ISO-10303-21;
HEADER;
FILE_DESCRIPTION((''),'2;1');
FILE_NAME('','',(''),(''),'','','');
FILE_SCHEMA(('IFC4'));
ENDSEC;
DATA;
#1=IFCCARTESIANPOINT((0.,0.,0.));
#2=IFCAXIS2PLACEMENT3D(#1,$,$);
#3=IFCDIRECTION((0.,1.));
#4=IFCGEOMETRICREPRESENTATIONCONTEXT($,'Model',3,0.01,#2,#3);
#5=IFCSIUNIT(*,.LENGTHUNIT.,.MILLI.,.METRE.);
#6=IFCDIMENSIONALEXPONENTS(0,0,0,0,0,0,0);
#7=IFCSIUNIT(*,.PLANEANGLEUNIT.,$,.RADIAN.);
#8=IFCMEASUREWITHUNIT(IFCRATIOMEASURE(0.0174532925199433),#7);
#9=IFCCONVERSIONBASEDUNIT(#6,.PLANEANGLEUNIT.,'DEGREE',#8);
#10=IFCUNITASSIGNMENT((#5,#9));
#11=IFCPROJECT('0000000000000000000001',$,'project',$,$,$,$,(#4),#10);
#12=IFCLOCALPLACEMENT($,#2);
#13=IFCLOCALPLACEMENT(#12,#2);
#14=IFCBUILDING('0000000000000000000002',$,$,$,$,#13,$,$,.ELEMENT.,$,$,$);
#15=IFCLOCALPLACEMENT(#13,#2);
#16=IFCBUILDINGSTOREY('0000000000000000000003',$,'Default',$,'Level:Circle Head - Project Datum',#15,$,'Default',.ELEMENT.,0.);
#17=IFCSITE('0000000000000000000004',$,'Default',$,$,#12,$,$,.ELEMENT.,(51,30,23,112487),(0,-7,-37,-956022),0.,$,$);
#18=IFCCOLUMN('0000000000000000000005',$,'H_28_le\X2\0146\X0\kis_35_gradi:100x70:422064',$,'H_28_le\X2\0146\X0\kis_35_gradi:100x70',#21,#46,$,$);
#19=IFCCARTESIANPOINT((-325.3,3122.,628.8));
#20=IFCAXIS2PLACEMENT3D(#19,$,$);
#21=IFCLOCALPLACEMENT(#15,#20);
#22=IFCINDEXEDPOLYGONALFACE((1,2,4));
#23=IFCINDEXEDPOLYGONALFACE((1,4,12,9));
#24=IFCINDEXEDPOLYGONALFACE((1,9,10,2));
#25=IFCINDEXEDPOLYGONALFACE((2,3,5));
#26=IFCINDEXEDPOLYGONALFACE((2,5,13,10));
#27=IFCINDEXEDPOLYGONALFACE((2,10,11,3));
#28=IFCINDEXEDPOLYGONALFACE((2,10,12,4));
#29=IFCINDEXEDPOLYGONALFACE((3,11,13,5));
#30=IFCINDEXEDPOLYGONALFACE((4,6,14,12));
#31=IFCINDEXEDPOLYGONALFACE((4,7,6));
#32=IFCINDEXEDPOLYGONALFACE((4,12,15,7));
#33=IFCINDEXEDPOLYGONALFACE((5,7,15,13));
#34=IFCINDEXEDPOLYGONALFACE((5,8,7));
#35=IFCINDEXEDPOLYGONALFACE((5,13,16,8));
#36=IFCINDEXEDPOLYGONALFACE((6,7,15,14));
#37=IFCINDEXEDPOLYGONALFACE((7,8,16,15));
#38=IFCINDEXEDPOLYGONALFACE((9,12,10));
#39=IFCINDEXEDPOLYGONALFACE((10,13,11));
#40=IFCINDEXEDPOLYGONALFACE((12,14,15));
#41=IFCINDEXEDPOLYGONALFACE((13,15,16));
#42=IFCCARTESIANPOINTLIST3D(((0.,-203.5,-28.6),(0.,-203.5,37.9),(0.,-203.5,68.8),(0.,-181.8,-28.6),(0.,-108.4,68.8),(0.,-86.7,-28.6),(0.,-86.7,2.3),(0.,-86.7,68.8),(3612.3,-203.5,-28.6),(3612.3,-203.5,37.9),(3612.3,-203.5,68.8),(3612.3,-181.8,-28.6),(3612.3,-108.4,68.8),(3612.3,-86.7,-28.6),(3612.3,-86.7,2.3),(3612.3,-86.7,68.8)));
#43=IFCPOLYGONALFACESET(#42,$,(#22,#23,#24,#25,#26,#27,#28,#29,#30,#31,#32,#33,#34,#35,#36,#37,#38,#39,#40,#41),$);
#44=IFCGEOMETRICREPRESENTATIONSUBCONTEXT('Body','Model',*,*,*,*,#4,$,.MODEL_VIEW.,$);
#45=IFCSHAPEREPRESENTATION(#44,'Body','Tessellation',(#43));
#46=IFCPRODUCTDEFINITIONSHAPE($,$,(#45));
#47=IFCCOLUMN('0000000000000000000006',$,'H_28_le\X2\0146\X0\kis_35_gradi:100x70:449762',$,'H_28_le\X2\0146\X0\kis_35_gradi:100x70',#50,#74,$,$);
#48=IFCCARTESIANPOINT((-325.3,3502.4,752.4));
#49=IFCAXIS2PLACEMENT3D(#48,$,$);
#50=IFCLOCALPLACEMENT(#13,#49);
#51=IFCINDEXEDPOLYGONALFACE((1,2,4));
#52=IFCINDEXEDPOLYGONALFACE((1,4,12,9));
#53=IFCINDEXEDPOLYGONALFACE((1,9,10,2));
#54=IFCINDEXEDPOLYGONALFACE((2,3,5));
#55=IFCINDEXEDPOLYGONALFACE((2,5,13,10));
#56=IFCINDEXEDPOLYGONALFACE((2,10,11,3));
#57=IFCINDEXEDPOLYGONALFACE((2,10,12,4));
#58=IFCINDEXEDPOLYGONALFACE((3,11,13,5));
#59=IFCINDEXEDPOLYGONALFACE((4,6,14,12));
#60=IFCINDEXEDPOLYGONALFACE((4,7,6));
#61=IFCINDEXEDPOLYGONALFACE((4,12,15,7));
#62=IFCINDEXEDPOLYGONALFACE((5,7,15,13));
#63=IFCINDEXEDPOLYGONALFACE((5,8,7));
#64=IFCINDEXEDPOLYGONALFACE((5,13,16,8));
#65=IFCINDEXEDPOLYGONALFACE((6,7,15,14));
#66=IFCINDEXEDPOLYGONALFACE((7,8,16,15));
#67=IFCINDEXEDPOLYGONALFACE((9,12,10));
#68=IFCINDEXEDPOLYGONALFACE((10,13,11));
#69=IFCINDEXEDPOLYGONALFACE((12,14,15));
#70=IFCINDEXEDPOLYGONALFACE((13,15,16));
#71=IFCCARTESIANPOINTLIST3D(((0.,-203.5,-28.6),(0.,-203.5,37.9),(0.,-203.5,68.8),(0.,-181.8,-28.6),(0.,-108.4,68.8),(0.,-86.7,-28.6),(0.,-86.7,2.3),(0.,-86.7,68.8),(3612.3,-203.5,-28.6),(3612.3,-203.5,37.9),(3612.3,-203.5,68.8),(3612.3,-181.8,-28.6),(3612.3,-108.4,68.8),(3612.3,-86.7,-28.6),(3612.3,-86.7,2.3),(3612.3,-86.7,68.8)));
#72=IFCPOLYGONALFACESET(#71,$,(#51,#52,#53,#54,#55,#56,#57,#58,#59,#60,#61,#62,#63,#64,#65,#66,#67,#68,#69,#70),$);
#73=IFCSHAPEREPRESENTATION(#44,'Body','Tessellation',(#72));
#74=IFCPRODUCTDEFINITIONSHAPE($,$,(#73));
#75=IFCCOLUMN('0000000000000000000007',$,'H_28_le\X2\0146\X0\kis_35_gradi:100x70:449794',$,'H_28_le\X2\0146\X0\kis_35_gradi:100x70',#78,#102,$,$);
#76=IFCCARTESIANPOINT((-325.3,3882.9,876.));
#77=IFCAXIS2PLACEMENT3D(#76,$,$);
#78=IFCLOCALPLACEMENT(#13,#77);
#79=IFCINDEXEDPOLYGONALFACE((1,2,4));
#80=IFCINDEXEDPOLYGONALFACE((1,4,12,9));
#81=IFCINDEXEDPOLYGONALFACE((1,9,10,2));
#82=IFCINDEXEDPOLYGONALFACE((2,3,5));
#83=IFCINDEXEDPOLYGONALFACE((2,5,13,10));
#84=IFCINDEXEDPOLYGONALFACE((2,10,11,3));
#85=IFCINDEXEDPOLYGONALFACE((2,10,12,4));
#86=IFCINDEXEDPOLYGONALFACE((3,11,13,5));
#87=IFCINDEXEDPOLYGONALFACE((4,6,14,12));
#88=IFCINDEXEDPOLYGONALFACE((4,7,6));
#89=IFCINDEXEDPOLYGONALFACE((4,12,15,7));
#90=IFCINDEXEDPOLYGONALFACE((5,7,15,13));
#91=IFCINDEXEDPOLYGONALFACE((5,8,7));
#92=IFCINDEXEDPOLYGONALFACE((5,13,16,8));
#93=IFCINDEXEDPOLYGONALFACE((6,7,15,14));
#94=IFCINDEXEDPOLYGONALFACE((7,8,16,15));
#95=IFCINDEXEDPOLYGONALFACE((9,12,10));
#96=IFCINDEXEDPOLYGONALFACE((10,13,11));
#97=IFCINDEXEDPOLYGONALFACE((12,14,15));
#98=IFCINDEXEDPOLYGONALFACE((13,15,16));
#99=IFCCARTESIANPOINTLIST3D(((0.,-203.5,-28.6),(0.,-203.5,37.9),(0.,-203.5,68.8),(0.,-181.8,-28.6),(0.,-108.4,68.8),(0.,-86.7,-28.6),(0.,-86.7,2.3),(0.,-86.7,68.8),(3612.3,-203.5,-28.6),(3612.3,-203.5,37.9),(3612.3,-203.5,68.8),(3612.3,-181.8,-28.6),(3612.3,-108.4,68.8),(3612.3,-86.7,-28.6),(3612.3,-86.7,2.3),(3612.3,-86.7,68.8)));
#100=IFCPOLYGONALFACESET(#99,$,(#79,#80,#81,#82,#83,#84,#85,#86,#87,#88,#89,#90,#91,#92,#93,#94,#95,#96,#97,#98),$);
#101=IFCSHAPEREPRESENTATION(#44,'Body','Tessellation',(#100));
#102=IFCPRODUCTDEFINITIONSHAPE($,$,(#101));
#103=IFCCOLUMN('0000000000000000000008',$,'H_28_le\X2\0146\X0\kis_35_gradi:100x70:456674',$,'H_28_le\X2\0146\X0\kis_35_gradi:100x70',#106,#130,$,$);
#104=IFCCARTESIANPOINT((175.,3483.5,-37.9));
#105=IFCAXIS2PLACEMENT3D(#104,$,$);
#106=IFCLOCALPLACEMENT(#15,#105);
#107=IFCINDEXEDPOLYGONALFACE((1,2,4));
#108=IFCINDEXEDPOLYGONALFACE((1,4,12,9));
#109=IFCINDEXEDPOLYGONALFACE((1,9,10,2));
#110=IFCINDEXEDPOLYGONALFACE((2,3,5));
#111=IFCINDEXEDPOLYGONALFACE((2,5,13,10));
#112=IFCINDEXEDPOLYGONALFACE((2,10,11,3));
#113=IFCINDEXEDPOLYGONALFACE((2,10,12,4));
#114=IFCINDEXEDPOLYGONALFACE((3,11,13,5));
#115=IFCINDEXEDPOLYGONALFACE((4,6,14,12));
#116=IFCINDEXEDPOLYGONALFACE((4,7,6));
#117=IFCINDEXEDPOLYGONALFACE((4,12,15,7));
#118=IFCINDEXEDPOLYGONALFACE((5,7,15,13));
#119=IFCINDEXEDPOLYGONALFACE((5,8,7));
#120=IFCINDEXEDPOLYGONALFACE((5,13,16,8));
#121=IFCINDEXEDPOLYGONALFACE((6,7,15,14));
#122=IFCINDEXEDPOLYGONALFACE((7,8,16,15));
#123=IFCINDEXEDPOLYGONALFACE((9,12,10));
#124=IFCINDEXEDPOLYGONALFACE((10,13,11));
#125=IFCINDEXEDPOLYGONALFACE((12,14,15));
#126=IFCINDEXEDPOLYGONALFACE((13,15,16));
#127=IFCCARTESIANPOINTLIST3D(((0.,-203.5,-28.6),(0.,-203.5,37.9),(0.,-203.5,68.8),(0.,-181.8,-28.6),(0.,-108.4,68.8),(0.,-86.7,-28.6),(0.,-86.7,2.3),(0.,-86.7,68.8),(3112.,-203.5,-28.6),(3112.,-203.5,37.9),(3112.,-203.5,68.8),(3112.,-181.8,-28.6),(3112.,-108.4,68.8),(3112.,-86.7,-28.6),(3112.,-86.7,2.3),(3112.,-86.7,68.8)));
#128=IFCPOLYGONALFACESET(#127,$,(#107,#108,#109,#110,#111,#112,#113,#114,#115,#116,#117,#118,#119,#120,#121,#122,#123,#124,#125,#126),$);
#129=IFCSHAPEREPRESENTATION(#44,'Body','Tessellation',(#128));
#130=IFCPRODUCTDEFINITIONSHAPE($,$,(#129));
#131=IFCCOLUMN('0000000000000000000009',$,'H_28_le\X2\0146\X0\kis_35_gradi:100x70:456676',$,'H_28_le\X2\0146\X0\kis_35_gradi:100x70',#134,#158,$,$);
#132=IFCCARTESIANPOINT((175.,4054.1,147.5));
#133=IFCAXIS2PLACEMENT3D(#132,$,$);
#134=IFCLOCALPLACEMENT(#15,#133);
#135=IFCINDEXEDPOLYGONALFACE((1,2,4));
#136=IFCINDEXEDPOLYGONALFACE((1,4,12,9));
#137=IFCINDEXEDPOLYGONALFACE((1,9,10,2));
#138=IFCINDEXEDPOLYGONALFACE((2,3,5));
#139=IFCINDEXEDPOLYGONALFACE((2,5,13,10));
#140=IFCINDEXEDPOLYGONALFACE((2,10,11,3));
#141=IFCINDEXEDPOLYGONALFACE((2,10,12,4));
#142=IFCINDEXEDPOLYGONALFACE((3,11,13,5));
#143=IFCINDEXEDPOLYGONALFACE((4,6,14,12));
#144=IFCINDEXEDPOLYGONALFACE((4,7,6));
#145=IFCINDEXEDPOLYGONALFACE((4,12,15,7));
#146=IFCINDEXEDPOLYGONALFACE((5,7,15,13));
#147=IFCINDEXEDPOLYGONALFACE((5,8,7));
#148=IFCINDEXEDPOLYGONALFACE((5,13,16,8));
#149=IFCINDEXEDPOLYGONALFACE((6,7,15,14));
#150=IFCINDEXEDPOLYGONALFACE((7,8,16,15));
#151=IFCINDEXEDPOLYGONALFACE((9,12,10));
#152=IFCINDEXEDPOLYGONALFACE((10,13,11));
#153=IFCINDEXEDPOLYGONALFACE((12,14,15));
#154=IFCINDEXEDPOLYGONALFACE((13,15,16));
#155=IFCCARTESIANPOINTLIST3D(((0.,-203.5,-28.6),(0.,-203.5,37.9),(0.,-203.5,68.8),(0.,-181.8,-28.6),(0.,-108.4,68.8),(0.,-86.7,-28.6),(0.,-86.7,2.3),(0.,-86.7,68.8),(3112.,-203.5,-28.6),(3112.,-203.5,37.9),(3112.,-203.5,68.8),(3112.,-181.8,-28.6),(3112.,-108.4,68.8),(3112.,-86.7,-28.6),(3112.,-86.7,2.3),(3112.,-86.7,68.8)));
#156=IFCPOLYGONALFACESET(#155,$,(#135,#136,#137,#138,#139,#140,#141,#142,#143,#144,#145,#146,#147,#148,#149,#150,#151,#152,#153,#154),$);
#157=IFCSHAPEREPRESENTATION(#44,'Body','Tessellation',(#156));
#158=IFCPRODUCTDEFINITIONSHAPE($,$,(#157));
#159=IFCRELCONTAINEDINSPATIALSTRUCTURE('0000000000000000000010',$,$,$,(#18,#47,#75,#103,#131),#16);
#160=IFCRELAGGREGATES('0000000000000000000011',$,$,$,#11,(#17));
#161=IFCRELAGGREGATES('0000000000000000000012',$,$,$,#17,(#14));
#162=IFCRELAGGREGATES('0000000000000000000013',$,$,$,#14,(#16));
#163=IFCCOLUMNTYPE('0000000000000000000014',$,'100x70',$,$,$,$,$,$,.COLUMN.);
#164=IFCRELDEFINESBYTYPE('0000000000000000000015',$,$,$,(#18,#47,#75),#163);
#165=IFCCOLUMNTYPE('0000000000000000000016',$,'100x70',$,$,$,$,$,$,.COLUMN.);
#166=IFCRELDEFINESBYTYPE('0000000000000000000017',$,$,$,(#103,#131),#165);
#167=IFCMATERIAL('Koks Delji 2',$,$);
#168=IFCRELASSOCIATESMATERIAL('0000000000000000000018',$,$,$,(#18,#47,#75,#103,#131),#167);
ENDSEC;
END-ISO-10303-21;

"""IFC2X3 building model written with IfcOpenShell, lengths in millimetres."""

from ifc_helpers import new_model, entity, si_unit, converted_unit, direction, frame, frame_2d, origin, origin_2d_with_axis, place, context, subcontext, project, spatial, rectangle, extrude, boolean, source, transform, mapped, material, type_object, type_shapes, element, save


model = new_model("IFC2X3")

# Units and contexts
model_context = context("Model", 3, precision=0.01, world=origin(), true_north=direction((0.0, 1.0)))
body_context = subcontext(model_context, "Body", "Model", "MODEL_VIEW")
ifc_project = project(units=[si_unit("LENGTHUNIT", "METRE", prefix="MILLI"), converted_unit("PLANEANGLEUNIT", "DEGREE", entity("IfcRatioMeasure", 0.0174532925199433), si_unit("PLANEANGLEUNIT", "RADIAN"), dimensions=[0, 0, 0, 0, 0, 0, 0])], contexts=[model_context])

# Site, building, storey
site_placement = place(None, origin())
site = spatial("IfcSite", under=ifc_project, at=site_placement, Name="Default", CompositionType="ELEMENT", RefLatitude=(51, 30, 23, 112487), RefLongitude=(0, -7, -37, -956022), RefElevation=0.0)
building_placement = place(site_placement, origin())
building = spatial("IfcBuilding", under=site, at=building_placement, CompositionType="ELEMENT")
storey_placement = place(building_placement, origin())
storey = spatial("IfcBuildingStorey", under=building, at=storey_placement, Name="Default", ObjectType="Level:Circle Head - Project Datum", LongName="Default", CompositionType="ELEMENT", Elevation=0.0)

# Columns
ifc_material_1 = material(Name="Koks Delji 2")
column_type_1 = type_object("IfcColumnType", Name="100x70", PredefinedType="COLUMN")
shared_shape_1 = source(origin(), body_context, "Body", "CSG", [
    boolean("DIFFERENCE", extrude(rectangle(XDim=3612.3, YDim=116.7, at=origin_2d_with_axis()), frame((1806.1, -145.1, -28.6)), (0.0, 0.0, 1.0), 97.5), extrude(rectangle(XDim=70.0, YDim=100.0, at=frame_2d((0.0, 0.0), x_axis=(0.0, 1.0))), frame((0.0, -145.1, 20.1), z_axis=(-1.0, 0.0, 0.0), x_axis=(0.0, -0.951057, -0.309017)), (0.0, 0.0, -1.0), 3612.3)),
])
type_shapes(column_type_1, [shared_shape_1])
column_1_placement = place(storey_placement, frame((-325.3, 3122.0, 628.8)))
element("IfcColumn", 1, at=column_1_placement, inside=storey, type_object=column_type_1, material=ifc_material_1, Name="H_28_leņkis_35_gradi:100x70:422064", ObjectType="H_28_leņkis_35_gradi:100x70", context=body_context, shape_type="MappedRepresentation", body=[
    mapped(shared_shape_1, transform((0.0, 0.0, 0.0), scale=1.0)),
])
for number, where, name in (
    (2, (-325.3, 3502.4, 752.4), "H_28_leņkis_35_gradi:100x70:449762"),
    (3, (-325.3, 3882.9, 876.0), "H_28_leņkis_35_gradi:100x70:449794"),
):
    element("IfcColumn", number, at=place(building_placement, frame(where)), inside=storey, type_object=column_type_1, material=ifc_material_1, Name=name, ObjectType="H_28_leņkis_35_gradi:100x70", context=body_context, shape_type="MappedRepresentation", body=[
        mapped(shared_shape_1, transform((0.0, 0.0, 0.0), scale=1.0)),
    ])
column_type_2 = type_object("IfcColumnType", Name="100x70", PredefinedType="COLUMN")
shared_shape_2 = source(origin(), body_context, "Body", "CSG", [
    boolean("DIFFERENCE", extrude(rectangle(XDim=3112.0, YDim=116.7, at=origin_2d_with_axis()), frame((1556.0, -145.1, -28.6)), (0.0, 0.0, 1.0), 97.5), extrude(rectangle(XDim=70.0, YDim=100.0, at=frame_2d((0.0, 0.0), x_axis=(0.0, 1.0))), frame((0.0, -145.1, 20.1), z_axis=(-1.0, 0.0, 0.0), x_axis=(0.0, -0.951057, -0.309017)), (0.0, 0.0, -1.0), 3112.0)),
])
type_shapes(column_type_2, [shared_shape_2])
for number, where, name in (
    (4, (175.0, 3483.5, -37.9), "H_28_leņkis_35_gradi:100x70:456674"),
    (5, (175.0, 4054.1, 147.5), "H_28_leņkis_35_gradi:100x70:456676"),
):
    element("IfcColumn", number, at=place(storey_placement, frame(where)), inside=storey, type_object=column_type_2, material=ifc_material_1, Name=name, ObjectType="H_28_leņkis_35_gradi:100x70", context=body_context, shape_type="MappedRepresentation", body=[
        mapped(shared_shape_2, transform((0.0, 0.0, 0.0), scale=1.0)),
    ])

save(model, "model.ifc")
